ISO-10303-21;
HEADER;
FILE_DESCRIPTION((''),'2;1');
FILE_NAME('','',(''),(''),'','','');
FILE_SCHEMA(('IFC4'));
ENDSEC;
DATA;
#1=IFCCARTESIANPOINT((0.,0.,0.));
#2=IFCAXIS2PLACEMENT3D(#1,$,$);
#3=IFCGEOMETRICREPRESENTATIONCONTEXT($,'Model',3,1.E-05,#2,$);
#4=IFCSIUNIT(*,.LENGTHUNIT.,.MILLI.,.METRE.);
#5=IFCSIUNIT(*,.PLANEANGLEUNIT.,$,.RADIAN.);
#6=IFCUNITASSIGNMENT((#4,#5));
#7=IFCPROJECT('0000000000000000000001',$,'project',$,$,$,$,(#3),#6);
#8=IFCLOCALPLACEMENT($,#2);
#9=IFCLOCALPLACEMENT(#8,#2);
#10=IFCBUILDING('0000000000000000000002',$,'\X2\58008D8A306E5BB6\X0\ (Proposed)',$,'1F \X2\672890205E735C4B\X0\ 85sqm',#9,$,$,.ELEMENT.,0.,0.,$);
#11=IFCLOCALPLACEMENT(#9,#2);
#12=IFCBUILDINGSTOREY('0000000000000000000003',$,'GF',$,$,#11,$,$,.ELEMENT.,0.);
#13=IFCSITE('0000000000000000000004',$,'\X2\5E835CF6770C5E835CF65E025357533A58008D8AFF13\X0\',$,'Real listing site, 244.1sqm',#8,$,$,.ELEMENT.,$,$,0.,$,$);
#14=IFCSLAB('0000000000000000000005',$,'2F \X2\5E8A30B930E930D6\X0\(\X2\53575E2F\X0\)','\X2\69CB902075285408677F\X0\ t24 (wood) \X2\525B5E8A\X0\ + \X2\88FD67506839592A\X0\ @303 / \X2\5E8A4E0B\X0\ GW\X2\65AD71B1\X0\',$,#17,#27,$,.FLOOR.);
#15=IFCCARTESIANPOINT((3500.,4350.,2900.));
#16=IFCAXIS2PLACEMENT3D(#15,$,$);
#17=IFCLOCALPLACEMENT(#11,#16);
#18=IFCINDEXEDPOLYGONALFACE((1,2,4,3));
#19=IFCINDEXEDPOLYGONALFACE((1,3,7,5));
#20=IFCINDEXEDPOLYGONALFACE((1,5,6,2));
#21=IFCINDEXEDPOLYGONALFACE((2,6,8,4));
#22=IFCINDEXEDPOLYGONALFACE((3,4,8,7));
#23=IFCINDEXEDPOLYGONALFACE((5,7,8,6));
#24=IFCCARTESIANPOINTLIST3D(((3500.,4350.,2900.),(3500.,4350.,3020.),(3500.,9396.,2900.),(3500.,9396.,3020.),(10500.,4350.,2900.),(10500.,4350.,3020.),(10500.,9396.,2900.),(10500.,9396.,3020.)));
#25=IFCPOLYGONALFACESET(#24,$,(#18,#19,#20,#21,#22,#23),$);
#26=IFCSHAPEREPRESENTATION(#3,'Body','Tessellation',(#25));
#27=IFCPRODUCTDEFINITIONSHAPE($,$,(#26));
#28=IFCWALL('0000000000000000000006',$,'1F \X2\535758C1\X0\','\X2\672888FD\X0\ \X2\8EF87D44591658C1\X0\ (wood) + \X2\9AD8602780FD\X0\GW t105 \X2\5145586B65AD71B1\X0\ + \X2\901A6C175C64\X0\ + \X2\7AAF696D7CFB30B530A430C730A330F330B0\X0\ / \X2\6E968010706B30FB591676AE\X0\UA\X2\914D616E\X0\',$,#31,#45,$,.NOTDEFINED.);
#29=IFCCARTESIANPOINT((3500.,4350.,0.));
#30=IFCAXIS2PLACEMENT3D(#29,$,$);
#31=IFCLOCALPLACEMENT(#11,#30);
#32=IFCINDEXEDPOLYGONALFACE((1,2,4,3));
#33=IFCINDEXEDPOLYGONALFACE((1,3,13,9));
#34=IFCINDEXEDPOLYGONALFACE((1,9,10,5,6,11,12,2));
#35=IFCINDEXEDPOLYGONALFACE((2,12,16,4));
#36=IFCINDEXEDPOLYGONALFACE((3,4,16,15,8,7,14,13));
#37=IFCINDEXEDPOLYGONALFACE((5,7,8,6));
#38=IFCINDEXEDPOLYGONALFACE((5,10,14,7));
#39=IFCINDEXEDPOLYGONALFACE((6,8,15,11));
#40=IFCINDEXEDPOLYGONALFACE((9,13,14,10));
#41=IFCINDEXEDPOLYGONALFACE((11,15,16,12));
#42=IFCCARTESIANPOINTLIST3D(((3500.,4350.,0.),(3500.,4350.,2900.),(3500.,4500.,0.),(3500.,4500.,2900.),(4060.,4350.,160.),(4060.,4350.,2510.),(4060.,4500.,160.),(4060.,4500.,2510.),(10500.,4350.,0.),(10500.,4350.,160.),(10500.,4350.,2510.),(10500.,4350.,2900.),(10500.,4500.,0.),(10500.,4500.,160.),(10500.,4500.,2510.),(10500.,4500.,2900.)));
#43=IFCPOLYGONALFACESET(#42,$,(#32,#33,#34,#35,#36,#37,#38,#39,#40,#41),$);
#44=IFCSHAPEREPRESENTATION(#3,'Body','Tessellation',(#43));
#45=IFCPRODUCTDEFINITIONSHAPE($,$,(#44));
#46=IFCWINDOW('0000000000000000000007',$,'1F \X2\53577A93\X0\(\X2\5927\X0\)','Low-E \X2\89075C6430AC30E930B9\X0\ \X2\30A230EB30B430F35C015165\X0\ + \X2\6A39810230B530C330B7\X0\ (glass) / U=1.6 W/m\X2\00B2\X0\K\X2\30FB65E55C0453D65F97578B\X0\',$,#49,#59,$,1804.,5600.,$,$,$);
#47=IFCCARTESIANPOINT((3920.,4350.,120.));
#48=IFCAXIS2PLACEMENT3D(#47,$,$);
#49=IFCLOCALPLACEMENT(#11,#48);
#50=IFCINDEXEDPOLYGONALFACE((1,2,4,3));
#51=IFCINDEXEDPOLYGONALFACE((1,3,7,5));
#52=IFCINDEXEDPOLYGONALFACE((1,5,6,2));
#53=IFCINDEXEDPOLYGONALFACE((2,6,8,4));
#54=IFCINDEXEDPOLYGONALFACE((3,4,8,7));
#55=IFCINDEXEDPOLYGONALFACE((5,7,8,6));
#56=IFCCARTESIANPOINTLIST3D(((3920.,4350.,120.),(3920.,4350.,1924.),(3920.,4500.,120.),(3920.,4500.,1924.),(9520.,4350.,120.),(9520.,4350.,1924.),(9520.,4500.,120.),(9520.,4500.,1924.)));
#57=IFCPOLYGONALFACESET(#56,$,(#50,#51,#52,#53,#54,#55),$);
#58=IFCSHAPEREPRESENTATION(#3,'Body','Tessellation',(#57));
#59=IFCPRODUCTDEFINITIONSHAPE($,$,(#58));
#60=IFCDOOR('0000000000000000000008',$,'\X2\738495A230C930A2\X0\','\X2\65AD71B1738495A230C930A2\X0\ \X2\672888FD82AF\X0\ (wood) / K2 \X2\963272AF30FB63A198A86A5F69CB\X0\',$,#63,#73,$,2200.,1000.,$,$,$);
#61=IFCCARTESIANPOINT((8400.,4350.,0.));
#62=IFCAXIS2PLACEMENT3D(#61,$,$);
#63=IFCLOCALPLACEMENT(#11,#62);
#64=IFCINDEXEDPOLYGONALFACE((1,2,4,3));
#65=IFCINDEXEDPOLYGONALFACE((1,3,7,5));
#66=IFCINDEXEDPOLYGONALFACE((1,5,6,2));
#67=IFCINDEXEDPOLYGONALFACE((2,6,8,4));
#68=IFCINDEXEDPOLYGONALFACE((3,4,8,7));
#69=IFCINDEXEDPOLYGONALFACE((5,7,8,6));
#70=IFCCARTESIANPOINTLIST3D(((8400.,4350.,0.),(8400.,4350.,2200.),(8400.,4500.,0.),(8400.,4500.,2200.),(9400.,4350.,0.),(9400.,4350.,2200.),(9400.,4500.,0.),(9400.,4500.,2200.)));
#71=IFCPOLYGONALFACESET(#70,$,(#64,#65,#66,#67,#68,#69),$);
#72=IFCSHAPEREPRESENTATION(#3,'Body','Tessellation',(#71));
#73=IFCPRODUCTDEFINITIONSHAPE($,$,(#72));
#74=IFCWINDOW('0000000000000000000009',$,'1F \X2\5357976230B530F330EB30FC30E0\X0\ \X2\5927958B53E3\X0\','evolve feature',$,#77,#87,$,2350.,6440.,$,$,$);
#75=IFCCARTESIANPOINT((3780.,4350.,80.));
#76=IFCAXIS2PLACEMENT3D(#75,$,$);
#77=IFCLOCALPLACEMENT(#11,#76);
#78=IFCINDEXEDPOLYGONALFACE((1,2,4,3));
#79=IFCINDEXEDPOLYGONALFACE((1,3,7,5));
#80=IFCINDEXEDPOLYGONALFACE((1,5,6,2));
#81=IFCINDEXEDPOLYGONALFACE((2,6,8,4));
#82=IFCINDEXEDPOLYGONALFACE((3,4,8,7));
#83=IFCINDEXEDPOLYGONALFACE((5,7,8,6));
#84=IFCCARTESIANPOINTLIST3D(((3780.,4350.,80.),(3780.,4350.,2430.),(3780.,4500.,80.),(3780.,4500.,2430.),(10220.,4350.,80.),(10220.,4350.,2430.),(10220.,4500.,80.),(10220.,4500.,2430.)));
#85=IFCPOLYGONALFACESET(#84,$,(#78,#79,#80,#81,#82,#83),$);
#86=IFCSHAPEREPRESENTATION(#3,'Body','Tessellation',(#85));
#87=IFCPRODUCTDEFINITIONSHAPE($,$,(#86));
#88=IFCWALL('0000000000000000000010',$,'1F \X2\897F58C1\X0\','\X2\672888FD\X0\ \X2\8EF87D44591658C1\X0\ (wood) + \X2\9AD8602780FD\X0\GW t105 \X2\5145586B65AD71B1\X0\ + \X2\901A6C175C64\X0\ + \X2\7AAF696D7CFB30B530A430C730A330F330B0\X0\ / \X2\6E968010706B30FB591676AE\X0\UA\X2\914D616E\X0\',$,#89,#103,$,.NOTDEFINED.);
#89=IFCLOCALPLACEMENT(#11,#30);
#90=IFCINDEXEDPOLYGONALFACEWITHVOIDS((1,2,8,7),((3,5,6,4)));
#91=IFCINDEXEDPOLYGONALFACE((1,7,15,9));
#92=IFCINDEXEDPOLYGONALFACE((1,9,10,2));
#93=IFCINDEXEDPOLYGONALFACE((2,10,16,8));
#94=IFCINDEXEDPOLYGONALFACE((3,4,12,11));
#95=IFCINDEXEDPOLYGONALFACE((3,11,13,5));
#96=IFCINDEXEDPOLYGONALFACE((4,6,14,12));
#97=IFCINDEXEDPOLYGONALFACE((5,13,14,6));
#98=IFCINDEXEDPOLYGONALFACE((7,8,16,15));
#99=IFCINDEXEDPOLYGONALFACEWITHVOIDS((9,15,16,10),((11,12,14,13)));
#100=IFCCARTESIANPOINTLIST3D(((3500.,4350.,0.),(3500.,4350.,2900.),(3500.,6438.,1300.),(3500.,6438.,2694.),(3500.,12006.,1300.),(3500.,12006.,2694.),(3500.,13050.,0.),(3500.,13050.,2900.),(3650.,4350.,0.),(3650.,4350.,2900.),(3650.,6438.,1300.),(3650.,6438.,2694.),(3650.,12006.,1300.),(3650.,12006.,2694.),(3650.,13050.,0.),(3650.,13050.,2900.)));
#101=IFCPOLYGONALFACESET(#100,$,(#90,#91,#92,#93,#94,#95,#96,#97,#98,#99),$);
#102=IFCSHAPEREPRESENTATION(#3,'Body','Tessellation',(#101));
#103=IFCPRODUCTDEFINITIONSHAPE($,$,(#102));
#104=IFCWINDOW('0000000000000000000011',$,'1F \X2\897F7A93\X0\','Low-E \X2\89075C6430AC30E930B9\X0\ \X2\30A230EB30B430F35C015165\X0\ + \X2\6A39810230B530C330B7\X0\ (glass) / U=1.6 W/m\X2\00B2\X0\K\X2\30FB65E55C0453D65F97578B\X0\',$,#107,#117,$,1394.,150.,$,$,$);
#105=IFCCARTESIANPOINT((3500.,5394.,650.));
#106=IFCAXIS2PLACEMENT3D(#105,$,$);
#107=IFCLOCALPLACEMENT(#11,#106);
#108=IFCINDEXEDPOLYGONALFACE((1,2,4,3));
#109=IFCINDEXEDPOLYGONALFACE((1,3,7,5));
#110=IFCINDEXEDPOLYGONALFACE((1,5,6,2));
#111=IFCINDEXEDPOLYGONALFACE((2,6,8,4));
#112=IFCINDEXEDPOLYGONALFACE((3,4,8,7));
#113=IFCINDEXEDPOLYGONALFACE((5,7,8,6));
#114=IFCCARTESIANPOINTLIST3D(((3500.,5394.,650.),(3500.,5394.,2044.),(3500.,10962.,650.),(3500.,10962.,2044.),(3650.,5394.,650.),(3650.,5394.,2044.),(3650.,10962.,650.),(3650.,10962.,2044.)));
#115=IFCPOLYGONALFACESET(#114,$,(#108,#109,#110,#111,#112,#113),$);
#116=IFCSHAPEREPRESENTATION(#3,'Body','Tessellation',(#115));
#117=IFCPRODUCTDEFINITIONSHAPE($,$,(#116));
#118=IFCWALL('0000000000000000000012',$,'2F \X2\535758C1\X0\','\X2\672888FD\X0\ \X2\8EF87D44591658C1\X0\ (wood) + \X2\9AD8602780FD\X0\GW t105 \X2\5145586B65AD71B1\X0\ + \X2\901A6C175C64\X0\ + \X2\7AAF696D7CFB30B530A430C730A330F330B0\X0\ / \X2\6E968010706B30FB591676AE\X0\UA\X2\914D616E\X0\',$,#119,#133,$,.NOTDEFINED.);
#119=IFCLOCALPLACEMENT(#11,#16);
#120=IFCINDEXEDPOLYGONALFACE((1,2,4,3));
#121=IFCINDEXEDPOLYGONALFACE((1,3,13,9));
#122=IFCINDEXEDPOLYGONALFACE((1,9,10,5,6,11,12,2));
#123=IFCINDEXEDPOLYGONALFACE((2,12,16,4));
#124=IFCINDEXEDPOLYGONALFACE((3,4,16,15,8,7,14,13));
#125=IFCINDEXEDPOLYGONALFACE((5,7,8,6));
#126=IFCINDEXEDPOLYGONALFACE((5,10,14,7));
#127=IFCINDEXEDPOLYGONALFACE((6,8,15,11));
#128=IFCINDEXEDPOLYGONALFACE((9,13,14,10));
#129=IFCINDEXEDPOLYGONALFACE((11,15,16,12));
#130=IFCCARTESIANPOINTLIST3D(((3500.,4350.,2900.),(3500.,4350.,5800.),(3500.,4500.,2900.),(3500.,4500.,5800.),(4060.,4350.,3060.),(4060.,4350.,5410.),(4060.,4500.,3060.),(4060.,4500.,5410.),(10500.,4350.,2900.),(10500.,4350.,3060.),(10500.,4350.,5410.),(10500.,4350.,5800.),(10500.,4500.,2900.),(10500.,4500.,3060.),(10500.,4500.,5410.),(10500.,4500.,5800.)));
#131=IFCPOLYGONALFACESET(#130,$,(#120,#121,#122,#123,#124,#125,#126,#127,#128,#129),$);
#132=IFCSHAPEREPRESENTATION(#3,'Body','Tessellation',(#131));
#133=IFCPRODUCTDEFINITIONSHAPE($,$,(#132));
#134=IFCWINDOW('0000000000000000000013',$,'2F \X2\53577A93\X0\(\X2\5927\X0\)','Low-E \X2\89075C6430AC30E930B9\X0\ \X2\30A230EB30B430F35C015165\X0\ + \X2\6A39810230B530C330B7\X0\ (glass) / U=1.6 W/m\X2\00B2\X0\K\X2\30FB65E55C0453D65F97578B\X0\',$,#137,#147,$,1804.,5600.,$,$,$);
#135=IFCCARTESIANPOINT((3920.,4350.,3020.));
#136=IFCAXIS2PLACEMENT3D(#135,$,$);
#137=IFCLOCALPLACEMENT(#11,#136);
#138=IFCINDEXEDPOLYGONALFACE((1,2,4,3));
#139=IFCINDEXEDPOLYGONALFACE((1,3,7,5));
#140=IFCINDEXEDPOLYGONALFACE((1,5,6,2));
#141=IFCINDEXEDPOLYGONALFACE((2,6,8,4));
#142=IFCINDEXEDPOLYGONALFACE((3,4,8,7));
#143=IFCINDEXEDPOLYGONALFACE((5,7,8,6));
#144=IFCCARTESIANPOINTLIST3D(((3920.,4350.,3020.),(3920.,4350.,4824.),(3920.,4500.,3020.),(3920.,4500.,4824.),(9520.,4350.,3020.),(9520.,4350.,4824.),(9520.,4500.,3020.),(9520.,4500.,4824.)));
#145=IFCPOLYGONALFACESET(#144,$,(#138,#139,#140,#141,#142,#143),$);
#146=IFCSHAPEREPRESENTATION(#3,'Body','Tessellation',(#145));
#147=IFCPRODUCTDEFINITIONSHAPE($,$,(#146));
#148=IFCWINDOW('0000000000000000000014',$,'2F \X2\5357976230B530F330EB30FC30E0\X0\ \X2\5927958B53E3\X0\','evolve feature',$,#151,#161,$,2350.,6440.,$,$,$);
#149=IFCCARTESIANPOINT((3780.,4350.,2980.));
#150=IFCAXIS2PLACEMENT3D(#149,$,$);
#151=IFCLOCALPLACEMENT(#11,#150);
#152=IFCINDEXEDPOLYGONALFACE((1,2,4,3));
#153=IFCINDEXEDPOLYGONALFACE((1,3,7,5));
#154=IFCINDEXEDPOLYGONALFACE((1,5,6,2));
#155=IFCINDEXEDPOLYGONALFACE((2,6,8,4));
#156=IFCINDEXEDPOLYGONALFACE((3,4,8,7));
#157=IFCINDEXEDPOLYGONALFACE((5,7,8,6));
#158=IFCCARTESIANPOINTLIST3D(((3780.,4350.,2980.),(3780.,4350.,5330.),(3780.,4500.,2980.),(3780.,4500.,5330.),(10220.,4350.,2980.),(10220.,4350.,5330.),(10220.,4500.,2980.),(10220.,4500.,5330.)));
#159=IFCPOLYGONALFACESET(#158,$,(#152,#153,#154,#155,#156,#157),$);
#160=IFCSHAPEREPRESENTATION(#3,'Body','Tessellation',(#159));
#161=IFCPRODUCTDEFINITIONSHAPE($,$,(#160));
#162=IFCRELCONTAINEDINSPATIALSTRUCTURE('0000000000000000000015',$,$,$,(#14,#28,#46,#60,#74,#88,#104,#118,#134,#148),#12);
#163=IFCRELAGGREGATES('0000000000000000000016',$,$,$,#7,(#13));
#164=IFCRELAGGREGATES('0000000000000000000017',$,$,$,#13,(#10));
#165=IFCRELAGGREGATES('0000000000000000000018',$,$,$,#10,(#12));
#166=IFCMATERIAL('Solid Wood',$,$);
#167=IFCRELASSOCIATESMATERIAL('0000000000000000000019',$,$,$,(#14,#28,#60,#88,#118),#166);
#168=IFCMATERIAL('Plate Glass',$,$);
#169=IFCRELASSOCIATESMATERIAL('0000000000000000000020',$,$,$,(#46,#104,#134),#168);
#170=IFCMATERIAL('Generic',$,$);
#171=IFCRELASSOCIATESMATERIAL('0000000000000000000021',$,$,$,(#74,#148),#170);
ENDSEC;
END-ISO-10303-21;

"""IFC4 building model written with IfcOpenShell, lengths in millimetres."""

from ifc_helpers import new_model, si_unit, frame, frame_2d, origin, place, context, project, spatial, rectangle, extrude, material, element, fill, save


model = new_model("IFC4")

# Units and contexts
model_context = context("Model", 3, precision=1e-05, world=origin())
ifc_project = project(units=[si_unit("LENGTHUNIT", "METRE", prefix="MILLI"), si_unit("PLANEANGLEUNIT", "RADIAN")], contexts=[model_context])

# Site, building, storey
site_placement = place(None, origin())
site = spatial("IfcSite", under=ifc_project, at=site_placement, Name="広島県広島市南区堀越３", ObjectType="Real listing site, 244.1sqm", CompositionType="ELEMENT", RefElevation=0.0)
building_placement = place(site_placement, origin())
building = spatial("IfcBuilding", under=site, at=building_placement, Name="堀越の家 (Proposed)", ObjectType="1F 木造平屋 85sqm", CompositionType="ELEMENT", ElevationOfRefHeight=0.0, ElevationOfTerrain=0.0)
storey_placement = place(building_placement, origin())
storey = spatial("IfcBuildingStorey", under=building, at=storey_placement, Name="GF", CompositionType="ELEMENT", Elevation=0.0)

# Slab
ifc_material_1 = material(Name="Solid Wood")
slab_1_placement = place(storey_placement, frame((3500.0, 4350.0, 2900.0)))
element("IfcSlab", 1, at=slab_1_placement, inside=storey, material=ifc_material_1, Name="2F 床スラブ(南帯)", Description="構造用合板 t24 (wood) 剛床 + 製材根太 @303 / 床下 GW断熱", PredefinedType="FLOOR", context=model_context, shape_type="SweptSolid", body=[
    extrude(rectangle(XDim=7000.0, YDim=5046.0, at=frame_2d((3500.0, 2523.0))), frame((3500.0, 4350.0, 2900.0)), (0.0, 0.0, 1.0), 120.0),
])
ifc_material_2 = material(Name="Generic")

# Wall, openings, windows, door
wall_1_placement = place(storey_placement, frame((3500.0, 4350.0, 0.0)))
wall_1 = element("IfcWall", 2, at=wall_1_placement, inside=storey, material=ifc_material_1, Name="1F 南壁", Description="木製 軸組外壁 (wood) + 高性能GW t105 充填断熱 + 通気層 + 窯業系サイディング / 準耐火・外皮UA配慮", PredefinedType="NOTDEFINED", context=model_context, shape_type="SweptSolid", body=[
    extrude(rectangle(XDim=7000.0, YDim=150.0, at=frame_2d((3500.0, 75.0))), frame((3500.0, 4350.0, 0.0)), (0.0, 0.0, 1.0), 2900.0),
])
opening_1_placement = place(storey_placement, frame((3920.0, 4350.0, 120.0)))
opening_1 = element("IfcOpeningElement", 3, at=opening_1_placement, cuts=wall_1, PredefinedType="NOTDEFINED", context=model_context, shape_type="SweptSolid", body=[
    extrude(rectangle(XDim=5600.0, YDim=150.0, at=frame_2d((2800.0, 75.0))), frame((3920.0, 4350.0, 120.0)), (0.0, 0.0, 1.0), 1804.0),
])
opening_2_placement = place(storey_placement, frame((8400.0, 4350.0, 0.0)))
opening_2 = element("IfcOpeningElement", 4, at=opening_2_placement, cuts=wall_1, PredefinedType="NOTDEFINED", context=model_context, shape_type="SweptSolid", body=[
    extrude(rectangle(XDim=1000.0, YDim=150.0, at=frame_2d((500.0, 75.0))), frame((8400.0, 4350.0, 0.0)), (0.0, 0.0, 1.0), 2200.0),
])
opening_3_placement = place(storey_placement, frame((3780.0, 4350.0, 80.0)))
opening_3 = element("IfcOpeningElement", 5, at=opening_3_placement, cuts=wall_1, PredefinedType="NOTDEFINED", context=model_context, shape_type="SweptSolid", body=[
    extrude(rectangle(XDim=6440.0, YDim=150.0, at=frame_2d((3220.0, 75.0))), frame((3780.0, 4350.0, 80.0)), (0.0, 0.0, 1.0), 2350.0),
])
ifc_material_3 = material(Name="Plate Glass")
window_1_placement = place(storey_placement, frame((3920.0, 4350.0, 120.0)))
window_1 = element("IfcWindow", 6, at=window_1_placement, inside=storey, material=ifc_material_3, Name="1F 南窓(大)", Description="Low-E 複層ガラス アルゴン封入 + 樹脂サッシ (glass) / U=1.6 W/m²K・日射取得型", OverallHeight=1804.0, OverallWidth=5600.0, context=model_context, shape_type="SweptSolid", body=[
    extrude(rectangle(XDim=5600.0, YDim=150.0, at=frame_2d((2800.0, 75.0))), frame((3920.0, 4350.0, 120.0)), (0.0, 0.0, 1.0), 1804.0),
])
fill(opening_1, window_1)
door_placement = place(storey_placement, frame((8400.0, 4350.0, 0.0)))
door = element("IfcDoor", 7, at=door_placement, inside=storey, material=ifc_material_1, Name="玄関ドア", Description="断熱玄関ドア 木製芯 (wood) / K2 防犯・採風機構", OverallHeight=2200.0, OverallWidth=1000.0, context=model_context, shape_type="SweptSolid", body=[
    extrude(rectangle(XDim=1000.0, YDim=150.0, at=frame_2d((500.0, 75.0))), frame((8400.0, 4350.0, 0.0)), (0.0, 0.0, 1.0), 2200.0),
])
fill(opening_2, door)
window_2_placement = place(storey_placement, frame((3780.0, 4350.0, 80.0)))
window_2 = element("IfcWindow", 8, at=window_2_placement, inside=storey, material=ifc_material_2, Name="1F 南面サンルーム 大開口", Description="evolve feature", OverallHeight=2350.0, OverallWidth=6440.0, context=model_context, shape_type="SweptSolid", body=[
    extrude(rectangle(XDim=6440.0, YDim=150.0, at=frame_2d((3220.0, 75.0))), frame((3780.0, 4350.0, 80.0)), (0.0, 0.0, 1.0), 2350.0),
])
fill(opening_3, window_2)

# Wall, opening, window
wall_2_placement = place(storey_placement, frame((3500.0, 4350.0, 0.0)))
wall_2 = element("IfcWall", 9, at=wall_2_placement, inside=storey, material=ifc_material_1, Name="1F 西壁", Description="木製 軸組外壁 (wood) + 高性能GW t105 充填断熱 + 通気層 + 窯業系サイディング / 準耐火・外皮UA配慮", PredefinedType="NOTDEFINED", context=model_context, shape_type="SweptSolid", body=[
    extrude(rectangle(XDim=150.0, YDim=8700.0, at=frame_2d((75.0, 4350.0))), frame((3500.0, 4350.0, 0.0)), (0.0, 0.0, 1.0), 2900.0),
])
opening_4_placement = place(storey_placement, frame((3500.0, 5394.0, 650.0)))
opening_4 = element("IfcOpeningElement", 10, at=opening_4_placement, cuts=wall_2, PredefinedType="NOTDEFINED", context=model_context, shape_type="SweptSolid", body=[
    extrude(rectangle(XDim=150.0, YDim=5568.0, at=frame_2d((75.0, 2784.0))), frame((3500.0, 5394.0, 650.0)), (0.0, 0.0, 1.0), 1394.0),
])
window_3_placement = place(storey_placement, frame((3500.0, 5394.0, 650.0)))
window_3 = element("IfcWindow", 11, at=window_3_placement, inside=storey, material=ifc_material_3, Name="1F 西窓", Description="Low-E 複層ガラス アルゴン封入 + 樹脂サッシ (glass) / U=1.6 W/m²K・日射取得型", OverallHeight=1394.0, OverallWidth=150.0, context=model_context, shape_type="SweptSolid", body=[
    extrude(rectangle(XDim=150.0, YDim=5568.0, at=frame_2d((75.0, 2784.0))), frame((3500.0, 5394.0, 650.0)), (0.0, 0.0, 1.0), 1394.0),
])
fill(opening_4, window_3)

# Wall, openings, windows
wall_3_placement = place(storey_placement, frame((3500.0, 4350.0, 2900.0)))
wall_3 = element("IfcWall", 12, at=wall_3_placement, inside=storey, material=ifc_material_1, Name="2F 南壁", Description="木製 軸組外壁 (wood) + 高性能GW t105 充填断熱 + 通気層 + 窯業系サイディング / 準耐火・外皮UA配慮", PredefinedType="NOTDEFINED", context=model_context, shape_type="SweptSolid", body=[
    extrude(rectangle(XDim=7000.0, YDim=150.0, at=frame_2d((3500.0, 75.0))), frame((3500.0, 4350.0, 2900.0)), (0.0, 0.0, 1.0), 2900.0),
])
opening_5_placement = place(storey_placement, frame((3920.0, 4350.0, 3020.0)))
opening_5 = element("IfcOpeningElement", 13, at=opening_5_placement, cuts=wall_3, PredefinedType="NOTDEFINED", context=model_context, shape_type="SweptSolid", body=[
    extrude(rectangle(XDim=5600.0, YDim=150.0, at=frame_2d((2800.0, 75.0))), frame((3920.0, 4350.0, 3020.0)), (0.0, 0.0, 1.0), 1804.0),
])
opening_6_placement = place(storey_placement, frame((3780.0, 4350.0, 2980.0)))
opening_6 = element("IfcOpeningElement", 14, at=opening_6_placement, cuts=wall_3, PredefinedType="NOTDEFINED", context=model_context, shape_type="SweptSolid", body=[
    extrude(rectangle(XDim=6440.0, YDim=150.0, at=frame_2d((3220.0, 75.0))), frame((3780.0, 4350.0, 2980.0)), (0.0, 0.0, 1.0), 2350.0),
])
window_4_placement = place(storey_placement, frame((3920.0, 4350.0, 3020.0)))
window_4 = element("IfcWindow", 15, at=window_4_placement, inside=storey, material=ifc_material_3, Name="2F 南窓(大)", Description="Low-E 複層ガラス アルゴン封入 + 樹脂サッシ (glass) / U=1.6 W/m²K・日射取得型", OverallHeight=1804.0, OverallWidth=5600.0, context=model_context, shape_type="SweptSolid", body=[
    extrude(rectangle(XDim=5600.0, YDim=150.0, at=frame_2d((2800.0, 75.0))), frame((3920.0, 4350.0, 3020.0)), (0.0, 0.0, 1.0), 1804.0),
])
fill(opening_5, window_4)
window_5_placement = place(storey_placement, frame((3780.0, 4350.0, 2980.0)))
window_5 = element("IfcWindow", 16, at=window_5_placement, inside=storey, material=ifc_material_2, Name="2F 南面サンルーム 大開口", Description="evolve feature", OverallHeight=2350.0, OverallWidth=6440.0, context=model_context, shape_type="SweptSolid", body=[
    extrude(rectangle(XDim=6440.0, YDim=150.0, at=frame_2d((3220.0, 75.0))), frame((3780.0, 4350.0, 2980.0)), (0.0, 0.0, 1.0), 2350.0),
])
fill(opening_6, window_5)

save(model, "model.ifc")
